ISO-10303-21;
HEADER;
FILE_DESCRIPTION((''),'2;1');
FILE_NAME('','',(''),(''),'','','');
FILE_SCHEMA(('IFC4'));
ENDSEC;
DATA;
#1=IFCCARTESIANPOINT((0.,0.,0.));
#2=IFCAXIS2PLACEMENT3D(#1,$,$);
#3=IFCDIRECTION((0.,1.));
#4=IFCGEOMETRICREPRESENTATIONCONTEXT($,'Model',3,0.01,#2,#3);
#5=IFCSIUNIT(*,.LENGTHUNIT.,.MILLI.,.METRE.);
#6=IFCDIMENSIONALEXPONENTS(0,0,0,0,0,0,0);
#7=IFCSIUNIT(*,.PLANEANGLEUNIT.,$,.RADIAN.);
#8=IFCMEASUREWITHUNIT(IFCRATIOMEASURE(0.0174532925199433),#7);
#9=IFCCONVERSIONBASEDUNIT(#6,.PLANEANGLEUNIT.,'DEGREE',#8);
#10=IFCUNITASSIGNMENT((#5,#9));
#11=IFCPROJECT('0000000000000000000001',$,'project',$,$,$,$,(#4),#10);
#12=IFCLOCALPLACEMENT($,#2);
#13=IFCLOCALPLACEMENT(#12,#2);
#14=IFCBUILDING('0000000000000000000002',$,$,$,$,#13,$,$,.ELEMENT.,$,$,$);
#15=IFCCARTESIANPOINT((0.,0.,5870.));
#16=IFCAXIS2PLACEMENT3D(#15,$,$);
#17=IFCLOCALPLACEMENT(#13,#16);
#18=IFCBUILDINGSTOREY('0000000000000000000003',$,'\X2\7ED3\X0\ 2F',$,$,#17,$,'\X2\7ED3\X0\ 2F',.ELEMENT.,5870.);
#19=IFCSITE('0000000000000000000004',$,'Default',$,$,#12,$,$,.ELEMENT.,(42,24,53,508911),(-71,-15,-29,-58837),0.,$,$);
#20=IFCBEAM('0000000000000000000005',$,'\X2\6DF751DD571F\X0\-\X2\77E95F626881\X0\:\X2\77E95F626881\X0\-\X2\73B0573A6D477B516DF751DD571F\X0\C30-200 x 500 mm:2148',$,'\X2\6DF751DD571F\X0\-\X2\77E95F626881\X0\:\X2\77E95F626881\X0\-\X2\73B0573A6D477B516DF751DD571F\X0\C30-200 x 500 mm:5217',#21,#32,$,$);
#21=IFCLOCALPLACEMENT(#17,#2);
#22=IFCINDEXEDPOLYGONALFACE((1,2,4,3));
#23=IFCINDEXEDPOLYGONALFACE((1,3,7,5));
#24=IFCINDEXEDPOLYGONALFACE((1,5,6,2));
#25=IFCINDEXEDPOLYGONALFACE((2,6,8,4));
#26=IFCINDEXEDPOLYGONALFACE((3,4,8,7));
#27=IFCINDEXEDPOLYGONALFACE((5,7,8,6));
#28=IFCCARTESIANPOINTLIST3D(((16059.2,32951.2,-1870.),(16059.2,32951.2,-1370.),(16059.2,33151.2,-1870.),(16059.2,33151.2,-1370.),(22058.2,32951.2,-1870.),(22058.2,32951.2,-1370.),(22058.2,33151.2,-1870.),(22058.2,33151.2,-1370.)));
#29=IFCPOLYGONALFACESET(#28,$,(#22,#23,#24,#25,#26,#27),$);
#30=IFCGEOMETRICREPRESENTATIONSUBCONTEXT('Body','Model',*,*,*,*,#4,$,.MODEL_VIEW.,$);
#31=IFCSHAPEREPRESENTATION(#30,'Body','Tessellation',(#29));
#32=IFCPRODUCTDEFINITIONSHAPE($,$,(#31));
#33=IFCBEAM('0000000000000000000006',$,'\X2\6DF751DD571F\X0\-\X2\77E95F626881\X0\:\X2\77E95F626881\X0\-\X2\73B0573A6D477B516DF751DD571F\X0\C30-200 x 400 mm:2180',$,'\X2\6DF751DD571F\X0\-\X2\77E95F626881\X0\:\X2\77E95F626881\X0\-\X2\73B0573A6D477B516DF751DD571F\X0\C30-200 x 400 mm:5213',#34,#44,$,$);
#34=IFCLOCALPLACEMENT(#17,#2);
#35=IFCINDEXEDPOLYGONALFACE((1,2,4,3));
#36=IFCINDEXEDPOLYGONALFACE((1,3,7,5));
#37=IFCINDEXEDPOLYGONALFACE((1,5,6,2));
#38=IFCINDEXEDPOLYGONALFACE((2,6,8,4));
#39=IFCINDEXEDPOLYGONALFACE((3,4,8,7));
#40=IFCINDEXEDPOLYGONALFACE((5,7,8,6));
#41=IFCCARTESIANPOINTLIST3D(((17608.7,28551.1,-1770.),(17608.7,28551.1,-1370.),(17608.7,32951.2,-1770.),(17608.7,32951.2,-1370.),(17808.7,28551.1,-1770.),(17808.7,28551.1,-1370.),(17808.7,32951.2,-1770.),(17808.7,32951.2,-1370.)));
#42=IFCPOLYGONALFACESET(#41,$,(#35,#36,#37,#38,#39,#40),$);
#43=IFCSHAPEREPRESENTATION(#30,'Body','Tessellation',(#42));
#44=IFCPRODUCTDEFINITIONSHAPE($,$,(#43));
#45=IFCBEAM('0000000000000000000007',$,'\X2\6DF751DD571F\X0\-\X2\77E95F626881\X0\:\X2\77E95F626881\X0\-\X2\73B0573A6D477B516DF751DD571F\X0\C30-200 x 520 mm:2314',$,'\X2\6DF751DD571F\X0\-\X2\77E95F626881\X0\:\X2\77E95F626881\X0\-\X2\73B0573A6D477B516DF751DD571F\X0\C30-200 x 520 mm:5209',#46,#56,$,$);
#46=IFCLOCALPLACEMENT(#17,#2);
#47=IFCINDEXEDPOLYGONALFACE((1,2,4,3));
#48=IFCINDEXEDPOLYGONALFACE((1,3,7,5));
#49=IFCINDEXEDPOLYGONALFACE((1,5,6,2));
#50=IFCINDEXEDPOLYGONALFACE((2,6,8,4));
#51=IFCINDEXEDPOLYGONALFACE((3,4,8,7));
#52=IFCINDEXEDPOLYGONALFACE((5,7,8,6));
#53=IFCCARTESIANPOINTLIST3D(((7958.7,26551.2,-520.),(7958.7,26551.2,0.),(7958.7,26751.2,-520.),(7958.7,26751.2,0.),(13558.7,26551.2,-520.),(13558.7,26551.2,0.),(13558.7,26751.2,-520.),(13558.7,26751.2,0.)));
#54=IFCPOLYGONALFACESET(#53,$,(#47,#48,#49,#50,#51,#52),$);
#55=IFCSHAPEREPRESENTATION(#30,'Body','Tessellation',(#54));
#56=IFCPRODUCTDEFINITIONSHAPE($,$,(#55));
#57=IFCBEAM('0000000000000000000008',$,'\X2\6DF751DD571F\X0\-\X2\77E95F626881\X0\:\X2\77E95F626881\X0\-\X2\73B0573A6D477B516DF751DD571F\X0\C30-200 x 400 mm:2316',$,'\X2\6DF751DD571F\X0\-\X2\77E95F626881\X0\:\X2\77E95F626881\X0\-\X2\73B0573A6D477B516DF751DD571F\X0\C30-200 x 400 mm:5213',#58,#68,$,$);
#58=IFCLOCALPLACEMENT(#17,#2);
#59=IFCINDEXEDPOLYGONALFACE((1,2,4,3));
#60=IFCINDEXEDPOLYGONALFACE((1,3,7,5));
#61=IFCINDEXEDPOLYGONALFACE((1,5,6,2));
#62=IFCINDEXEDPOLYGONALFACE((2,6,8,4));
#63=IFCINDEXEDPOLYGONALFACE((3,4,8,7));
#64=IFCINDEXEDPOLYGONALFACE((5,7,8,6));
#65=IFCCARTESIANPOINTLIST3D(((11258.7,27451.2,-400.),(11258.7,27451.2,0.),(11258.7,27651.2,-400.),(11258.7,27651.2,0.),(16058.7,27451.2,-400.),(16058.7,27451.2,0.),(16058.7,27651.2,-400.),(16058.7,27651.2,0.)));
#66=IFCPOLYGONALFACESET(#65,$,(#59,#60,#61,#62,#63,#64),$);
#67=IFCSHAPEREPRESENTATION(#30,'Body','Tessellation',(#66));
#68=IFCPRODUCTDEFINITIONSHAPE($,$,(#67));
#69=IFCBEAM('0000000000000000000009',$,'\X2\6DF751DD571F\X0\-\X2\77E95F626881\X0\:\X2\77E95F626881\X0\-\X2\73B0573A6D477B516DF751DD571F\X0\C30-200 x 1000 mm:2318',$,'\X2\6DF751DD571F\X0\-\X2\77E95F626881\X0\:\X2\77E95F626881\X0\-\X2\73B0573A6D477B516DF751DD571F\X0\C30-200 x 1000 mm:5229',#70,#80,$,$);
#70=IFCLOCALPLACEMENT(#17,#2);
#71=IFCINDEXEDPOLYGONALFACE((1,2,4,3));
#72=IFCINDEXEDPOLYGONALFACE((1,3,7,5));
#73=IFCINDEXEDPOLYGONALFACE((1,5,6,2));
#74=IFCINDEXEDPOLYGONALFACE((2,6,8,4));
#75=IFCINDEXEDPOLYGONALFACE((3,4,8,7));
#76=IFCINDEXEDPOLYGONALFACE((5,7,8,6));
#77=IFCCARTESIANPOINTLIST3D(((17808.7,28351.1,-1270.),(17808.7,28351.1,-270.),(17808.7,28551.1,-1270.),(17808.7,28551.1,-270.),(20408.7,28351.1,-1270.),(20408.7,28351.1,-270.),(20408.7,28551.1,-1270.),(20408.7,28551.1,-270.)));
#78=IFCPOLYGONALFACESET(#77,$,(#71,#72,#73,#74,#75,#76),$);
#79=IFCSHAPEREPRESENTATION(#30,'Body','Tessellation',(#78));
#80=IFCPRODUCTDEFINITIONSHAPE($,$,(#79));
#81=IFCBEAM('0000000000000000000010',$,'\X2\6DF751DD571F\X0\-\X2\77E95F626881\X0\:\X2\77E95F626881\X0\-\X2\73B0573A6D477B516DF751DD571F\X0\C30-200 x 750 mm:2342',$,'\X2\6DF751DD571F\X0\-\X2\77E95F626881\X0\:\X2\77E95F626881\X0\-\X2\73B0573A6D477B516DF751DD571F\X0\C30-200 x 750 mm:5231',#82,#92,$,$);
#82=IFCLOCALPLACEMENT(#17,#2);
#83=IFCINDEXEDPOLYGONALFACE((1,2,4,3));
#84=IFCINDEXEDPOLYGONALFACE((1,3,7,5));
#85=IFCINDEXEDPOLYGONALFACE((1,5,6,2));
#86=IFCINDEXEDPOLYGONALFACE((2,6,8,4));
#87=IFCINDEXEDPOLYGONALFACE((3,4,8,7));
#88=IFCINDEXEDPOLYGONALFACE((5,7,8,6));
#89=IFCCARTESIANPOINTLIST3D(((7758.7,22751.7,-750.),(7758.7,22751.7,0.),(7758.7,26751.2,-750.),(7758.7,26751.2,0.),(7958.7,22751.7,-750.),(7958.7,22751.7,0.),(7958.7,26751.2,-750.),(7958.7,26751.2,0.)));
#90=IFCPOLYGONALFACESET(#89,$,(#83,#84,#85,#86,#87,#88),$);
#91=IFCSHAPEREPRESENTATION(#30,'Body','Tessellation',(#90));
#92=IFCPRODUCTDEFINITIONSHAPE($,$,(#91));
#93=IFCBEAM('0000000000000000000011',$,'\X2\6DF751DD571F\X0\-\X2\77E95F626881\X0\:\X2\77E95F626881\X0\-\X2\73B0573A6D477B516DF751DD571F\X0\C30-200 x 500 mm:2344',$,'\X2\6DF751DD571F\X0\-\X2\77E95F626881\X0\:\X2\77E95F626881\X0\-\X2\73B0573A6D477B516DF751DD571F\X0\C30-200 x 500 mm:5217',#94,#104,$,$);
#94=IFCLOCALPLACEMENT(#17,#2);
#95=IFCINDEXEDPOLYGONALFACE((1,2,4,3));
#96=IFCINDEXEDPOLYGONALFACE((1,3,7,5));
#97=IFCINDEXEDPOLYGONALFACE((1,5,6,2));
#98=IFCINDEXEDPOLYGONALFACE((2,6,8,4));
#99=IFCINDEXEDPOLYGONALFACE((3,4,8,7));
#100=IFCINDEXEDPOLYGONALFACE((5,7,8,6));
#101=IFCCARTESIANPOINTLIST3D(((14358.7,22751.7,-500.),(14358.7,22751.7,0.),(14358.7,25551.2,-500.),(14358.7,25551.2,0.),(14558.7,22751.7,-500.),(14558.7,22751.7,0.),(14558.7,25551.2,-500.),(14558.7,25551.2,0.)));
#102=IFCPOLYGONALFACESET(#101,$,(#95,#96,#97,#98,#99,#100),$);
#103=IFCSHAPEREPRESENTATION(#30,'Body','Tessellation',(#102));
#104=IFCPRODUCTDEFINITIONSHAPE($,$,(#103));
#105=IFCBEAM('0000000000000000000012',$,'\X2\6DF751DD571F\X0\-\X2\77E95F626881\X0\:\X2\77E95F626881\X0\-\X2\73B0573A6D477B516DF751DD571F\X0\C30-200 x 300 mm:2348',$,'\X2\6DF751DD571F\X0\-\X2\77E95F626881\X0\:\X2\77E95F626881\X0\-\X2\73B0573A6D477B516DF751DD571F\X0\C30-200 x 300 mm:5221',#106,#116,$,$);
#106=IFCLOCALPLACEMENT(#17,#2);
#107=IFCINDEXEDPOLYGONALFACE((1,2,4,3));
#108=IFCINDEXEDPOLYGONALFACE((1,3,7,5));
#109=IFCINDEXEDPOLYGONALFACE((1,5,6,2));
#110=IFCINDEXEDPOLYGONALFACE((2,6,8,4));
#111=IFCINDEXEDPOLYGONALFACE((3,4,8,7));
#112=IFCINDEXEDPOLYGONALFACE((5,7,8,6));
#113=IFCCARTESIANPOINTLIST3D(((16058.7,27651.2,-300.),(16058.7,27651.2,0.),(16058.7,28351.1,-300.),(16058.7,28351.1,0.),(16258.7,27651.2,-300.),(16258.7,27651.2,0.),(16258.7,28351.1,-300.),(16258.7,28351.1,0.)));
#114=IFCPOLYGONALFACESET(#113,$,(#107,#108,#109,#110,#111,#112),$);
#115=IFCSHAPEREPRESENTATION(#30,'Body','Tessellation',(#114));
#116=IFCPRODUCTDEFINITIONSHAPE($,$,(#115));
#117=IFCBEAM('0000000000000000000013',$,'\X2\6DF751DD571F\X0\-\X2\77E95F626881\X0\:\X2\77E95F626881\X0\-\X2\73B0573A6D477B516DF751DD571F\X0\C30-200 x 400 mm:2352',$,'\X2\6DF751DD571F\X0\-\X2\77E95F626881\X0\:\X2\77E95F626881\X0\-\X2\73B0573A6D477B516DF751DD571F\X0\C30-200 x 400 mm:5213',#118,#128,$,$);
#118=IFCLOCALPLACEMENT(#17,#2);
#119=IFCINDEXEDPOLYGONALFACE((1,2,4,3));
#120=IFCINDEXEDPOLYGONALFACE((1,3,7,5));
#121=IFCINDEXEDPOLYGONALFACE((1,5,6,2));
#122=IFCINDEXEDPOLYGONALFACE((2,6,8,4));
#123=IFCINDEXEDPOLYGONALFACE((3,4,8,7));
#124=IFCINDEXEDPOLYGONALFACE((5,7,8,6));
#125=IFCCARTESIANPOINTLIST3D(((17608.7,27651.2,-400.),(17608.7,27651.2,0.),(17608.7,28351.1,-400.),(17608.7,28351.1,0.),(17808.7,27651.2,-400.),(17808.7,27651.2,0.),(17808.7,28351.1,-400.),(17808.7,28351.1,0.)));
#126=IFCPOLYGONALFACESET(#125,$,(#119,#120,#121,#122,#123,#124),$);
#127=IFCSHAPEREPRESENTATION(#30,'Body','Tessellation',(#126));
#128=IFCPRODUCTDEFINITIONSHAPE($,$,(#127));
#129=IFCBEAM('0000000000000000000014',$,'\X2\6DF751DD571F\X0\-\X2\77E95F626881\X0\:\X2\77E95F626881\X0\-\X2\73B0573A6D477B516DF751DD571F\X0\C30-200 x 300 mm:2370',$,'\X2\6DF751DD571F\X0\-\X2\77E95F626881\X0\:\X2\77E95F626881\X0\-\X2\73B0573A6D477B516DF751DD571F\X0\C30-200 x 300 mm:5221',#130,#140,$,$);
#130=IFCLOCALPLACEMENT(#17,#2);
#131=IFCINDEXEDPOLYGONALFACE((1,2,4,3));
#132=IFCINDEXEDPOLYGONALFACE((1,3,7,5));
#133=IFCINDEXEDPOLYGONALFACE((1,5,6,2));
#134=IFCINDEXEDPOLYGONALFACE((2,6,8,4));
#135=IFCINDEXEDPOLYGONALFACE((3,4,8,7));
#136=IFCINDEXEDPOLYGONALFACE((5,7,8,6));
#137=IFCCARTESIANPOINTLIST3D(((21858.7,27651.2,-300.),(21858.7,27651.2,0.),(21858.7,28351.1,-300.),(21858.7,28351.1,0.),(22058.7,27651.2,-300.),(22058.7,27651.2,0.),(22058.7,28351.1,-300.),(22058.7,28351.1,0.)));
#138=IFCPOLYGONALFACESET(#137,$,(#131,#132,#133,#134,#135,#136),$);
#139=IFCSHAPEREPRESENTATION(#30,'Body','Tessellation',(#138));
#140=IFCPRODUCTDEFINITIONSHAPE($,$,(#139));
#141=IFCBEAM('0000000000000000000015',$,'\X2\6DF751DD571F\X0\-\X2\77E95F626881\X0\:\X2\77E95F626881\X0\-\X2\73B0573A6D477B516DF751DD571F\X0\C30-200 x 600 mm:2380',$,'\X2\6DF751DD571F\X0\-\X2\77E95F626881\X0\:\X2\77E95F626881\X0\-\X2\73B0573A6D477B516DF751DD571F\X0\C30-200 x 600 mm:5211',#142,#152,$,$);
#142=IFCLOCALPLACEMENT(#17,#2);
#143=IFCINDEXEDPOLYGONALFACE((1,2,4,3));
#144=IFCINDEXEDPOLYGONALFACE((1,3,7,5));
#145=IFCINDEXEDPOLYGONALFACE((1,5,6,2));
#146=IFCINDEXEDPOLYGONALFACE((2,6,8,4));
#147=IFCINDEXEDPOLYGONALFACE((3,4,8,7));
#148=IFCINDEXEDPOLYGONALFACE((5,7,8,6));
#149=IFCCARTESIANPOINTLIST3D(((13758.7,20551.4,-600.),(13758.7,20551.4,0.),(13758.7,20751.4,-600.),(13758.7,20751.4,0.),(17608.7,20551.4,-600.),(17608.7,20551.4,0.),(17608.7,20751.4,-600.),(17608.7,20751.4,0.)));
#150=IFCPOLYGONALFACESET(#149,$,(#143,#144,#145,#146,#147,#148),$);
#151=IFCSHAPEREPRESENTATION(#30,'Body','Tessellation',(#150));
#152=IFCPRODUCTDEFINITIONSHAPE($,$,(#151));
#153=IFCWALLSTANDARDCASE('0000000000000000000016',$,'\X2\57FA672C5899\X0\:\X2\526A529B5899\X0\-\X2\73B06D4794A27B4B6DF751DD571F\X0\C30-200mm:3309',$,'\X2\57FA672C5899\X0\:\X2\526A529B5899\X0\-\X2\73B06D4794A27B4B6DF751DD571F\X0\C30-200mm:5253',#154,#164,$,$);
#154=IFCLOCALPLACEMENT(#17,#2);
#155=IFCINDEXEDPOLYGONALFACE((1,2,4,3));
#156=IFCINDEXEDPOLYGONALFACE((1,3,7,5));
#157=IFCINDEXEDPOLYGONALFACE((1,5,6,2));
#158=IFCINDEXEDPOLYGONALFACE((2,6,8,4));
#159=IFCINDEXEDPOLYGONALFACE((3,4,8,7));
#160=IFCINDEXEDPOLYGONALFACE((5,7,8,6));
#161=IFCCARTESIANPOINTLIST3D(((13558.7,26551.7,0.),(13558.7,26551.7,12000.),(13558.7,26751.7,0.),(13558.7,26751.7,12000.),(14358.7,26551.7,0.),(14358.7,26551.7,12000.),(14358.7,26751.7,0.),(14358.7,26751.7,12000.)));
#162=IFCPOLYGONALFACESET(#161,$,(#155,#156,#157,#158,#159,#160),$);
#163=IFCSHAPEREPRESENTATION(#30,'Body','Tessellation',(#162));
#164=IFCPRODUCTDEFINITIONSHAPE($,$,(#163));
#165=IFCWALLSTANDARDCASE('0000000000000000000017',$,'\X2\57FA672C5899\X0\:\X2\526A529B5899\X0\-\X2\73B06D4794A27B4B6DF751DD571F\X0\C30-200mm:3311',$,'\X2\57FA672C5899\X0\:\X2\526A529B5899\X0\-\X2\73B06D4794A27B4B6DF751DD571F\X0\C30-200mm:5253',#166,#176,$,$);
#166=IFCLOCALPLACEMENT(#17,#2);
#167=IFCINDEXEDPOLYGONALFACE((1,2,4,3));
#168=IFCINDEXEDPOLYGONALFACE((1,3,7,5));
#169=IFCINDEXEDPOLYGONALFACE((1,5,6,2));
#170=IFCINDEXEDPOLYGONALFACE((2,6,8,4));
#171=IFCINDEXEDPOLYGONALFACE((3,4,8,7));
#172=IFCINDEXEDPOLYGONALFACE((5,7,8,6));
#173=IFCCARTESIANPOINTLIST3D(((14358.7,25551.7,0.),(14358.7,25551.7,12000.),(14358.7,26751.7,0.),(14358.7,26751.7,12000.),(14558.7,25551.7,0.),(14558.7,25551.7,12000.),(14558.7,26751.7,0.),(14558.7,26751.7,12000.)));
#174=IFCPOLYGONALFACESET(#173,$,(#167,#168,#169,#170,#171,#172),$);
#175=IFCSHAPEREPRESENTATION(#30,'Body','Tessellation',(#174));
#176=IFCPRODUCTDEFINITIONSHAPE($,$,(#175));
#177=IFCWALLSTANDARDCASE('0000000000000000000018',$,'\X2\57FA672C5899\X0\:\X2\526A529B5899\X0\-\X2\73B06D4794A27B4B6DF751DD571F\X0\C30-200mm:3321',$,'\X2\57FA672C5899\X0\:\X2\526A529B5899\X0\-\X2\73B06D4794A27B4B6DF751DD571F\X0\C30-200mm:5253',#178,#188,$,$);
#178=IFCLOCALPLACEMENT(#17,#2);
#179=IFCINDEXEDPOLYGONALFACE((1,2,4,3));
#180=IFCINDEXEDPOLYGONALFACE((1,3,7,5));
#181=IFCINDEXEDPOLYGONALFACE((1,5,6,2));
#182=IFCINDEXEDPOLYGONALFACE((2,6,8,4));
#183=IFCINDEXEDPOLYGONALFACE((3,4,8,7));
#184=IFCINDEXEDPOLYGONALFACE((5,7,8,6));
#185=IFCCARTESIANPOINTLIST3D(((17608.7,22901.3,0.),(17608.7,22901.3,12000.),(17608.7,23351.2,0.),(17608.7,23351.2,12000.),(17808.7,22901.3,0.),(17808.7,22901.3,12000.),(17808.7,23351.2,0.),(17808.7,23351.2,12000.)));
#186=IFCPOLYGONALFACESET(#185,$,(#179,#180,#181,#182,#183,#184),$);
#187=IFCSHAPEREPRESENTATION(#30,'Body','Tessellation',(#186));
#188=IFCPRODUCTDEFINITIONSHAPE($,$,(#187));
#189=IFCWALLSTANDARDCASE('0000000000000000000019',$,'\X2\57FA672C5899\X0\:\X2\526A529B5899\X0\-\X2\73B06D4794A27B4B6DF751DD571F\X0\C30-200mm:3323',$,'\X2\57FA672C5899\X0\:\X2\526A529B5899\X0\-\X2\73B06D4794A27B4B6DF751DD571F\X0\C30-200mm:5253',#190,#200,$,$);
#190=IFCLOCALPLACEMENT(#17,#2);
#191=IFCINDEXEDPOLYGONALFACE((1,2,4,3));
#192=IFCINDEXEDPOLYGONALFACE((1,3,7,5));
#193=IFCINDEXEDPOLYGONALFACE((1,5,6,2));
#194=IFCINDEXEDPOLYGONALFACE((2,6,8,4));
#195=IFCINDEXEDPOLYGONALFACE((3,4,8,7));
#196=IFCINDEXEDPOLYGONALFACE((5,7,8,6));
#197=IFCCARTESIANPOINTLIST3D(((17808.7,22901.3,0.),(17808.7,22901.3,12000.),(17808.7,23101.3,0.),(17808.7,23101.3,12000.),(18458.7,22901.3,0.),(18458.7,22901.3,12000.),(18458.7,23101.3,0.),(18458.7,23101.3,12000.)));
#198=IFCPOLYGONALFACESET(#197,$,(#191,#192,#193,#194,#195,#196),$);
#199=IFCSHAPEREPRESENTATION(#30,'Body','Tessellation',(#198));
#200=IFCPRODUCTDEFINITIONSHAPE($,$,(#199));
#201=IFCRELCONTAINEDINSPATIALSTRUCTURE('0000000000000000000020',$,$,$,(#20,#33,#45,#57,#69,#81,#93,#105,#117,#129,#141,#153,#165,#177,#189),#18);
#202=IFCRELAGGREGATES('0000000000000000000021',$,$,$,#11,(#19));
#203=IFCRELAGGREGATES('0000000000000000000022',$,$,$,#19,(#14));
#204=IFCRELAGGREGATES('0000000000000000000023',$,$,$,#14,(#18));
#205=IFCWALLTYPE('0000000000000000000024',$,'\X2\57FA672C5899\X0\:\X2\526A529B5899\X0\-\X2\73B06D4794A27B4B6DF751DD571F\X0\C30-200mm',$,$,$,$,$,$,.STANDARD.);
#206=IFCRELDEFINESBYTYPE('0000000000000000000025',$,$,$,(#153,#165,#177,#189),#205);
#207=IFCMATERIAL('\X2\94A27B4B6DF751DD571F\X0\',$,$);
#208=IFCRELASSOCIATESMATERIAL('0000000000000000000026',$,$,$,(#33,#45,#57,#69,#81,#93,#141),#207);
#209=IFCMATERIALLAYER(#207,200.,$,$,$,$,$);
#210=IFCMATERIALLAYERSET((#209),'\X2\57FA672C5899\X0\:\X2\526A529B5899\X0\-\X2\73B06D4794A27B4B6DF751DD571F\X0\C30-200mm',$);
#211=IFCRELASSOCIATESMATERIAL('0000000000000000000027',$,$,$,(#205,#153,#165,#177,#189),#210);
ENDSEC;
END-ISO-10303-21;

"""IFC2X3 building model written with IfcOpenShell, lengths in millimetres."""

from ifc_helpers import new_model, entity, si_unit, converted_unit, direction, frame, frame_2d, origin, place, context, subcontext, project, spatial, rectangle, extrude, material, layer, layer_set, layer_usage, type_object, element, save


model = new_model("IFC2X3")

# Units and contexts
model_context = context("Model", 3, precision=0.01, world=origin(), true_north=direction((0.0, 1.0)))
body_context = subcontext(model_context, "Body", "Model", "MODEL_VIEW")
ifc_project = project(units=[si_unit("LENGTHUNIT", "METRE", prefix="MILLI"), converted_unit("PLANEANGLEUNIT", "DEGREE", entity("IfcRatioMeasure", 0.0174532925199433), si_unit("PLANEANGLEUNIT", "RADIAN"), dimensions=[0, 0, 0, 0, 0, 0, 0])], contexts=[model_context])

# Site, building, storey
site_placement = place(None, origin())
site = spatial("IfcSite", under=ifc_project, at=site_placement, Name="Default", CompositionType="ELEMENT", RefLatitude=(42, 24, 53, 508911), RefLongitude=(-71, -15, -29, -58837), RefElevation=0.0)
building_placement = place(site_placement, origin())
building = spatial("IfcBuilding", under=site, at=building_placement, CompositionType="ELEMENT")
storey_placement = place(building_placement, frame((0.0, 0.0, 5870.0)))
storey = spatial("IfcBuildingStorey", under=building, at=storey_placement, Name="结 2F", LongName="结 2F", CompositionType="ELEMENT", Elevation=5870.0)

# Beams
beam_1_placement = place(storey_placement, frame((16058.7, 33151.2, -1370.0)))
element("IfcBeam", 1, at=beam_1_placement, inside=storey, Name="混凝土-矩形梁:矩形梁-现场浇筑混凝土C30-200 x 500 mm:2148", ObjectType="混凝土-矩形梁:矩形梁-现场浇筑混凝土C30-200 x 500 mm:5217", context=body_context, shape_type="SweptSolid", body=[
    extrude(rectangle(XDim=500.0, YDim=200.0, at=frame_2d((0.0, 0.0), x_axis=(1.0, 0.0))), frame((0.5, -100.0, -250.0), z_axis=(1.0, 0.0, 0.0), x_axis=(0.0, 0.0, -1.0)), (0.0, 0.0, 1.0), 5999.0),
])
ifc_material = material(Name="钢筋混凝土")
beam_2_placement = place(storey_placement, frame((17708.7, 28451.1, -1370.0), z_axis=(0.0, 0.0, 1.0), x_axis=(0.0, 1.0, 0.0)))
element("IfcBeam", 2, at=beam_2_placement, inside=storey, material=ifc_material, Name="混凝土-矩形梁:矩形梁-现场浇筑混凝土C30-200 x 400 mm:2180", ObjectType="混凝土-矩形梁:矩形梁-现场浇筑混凝土C30-200 x 400 mm:5213", context=body_context, shape_type="SweptSolid", body=[
    extrude(rectangle(XDim=400.0, YDim=200.0, at=frame_2d((0.0, 0.0), x_axis=(1.0, 0.0))), frame((100.0, 0.0, -200.0), z_axis=(1.0, 0.0, 0.0), x_axis=(0.0, 0.0, -1.0)), (0.0, 0.0, 1.0), 4400.1),
])
beam_3_placement = place(storey_placement, frame((7858.7, 26651.2, 0.0)))
element("IfcBeam", 3, at=beam_3_placement, inside=storey, material=ifc_material, Name="混凝土-矩形梁:矩形梁-现场浇筑混凝土C30-200 x 520 mm:2314", ObjectType="混凝土-矩形梁:矩形梁-现场浇筑混凝土C30-200 x 520 mm:5209", context=body_context, shape_type="SweptSolid", body=[
    extrude(rectangle(XDim=520.0, YDim=200.0, at=frame_2d((0.0, 0.0), x_axis=(1.0, 0.0))), frame((100.0, 0.0, -260.0), z_axis=(1.0, 0.0, 0.0), x_axis=(0.0, 0.0, -1.0)), (0.0, 0.0, 1.0), 5600.0),
])
beam_4_placement = place(storey_placement, frame((11158.7, 27551.2, 0.0)))
element("IfcBeam", 4, at=beam_4_placement, inside=storey, material=ifc_material, Name="混凝土-矩形梁:矩形梁-现场浇筑混凝土C30-200 x 400 mm:2316", ObjectType="混凝土-矩形梁:矩形梁-现场浇筑混凝土C30-200 x 400 mm:5213", context=body_context, shape_type="SweptSolid", body=[
    extrude(rectangle(XDim=400.0, YDim=200.0, at=frame_2d((0.0, 0.0), x_axis=(1.0, 0.0))), frame((100.0, 0.0, -200.0), z_axis=(1.0, 0.0, 0.0), x_axis=(0.0, 0.0, -1.0)), (0.0, 0.0, 1.0), 4800.0),
])
beam_5_placement = place(storey_placement, frame((16168.7, 28451.1, -270.0)))
element("IfcBeam", 5, at=beam_5_placement, inside=storey, material=ifc_material, Name="混凝土-矩形梁:矩形梁-现场浇筑混凝土C30-200 x 1000 mm:2318", ObjectType="混凝土-矩形梁:矩形梁-现场浇筑混凝土C30-200 x 1000 mm:5229", context=body_context, shape_type="SweptSolid", body=[
    extrude(rectangle(XDim=1000.0, YDim=200.0, at=frame_2d((0.0, 0.0), x_axis=(1.0, 0.0))), frame((1640.0, 0.0, -500.0), z_axis=(1.0, 0.0, 0.0), x_axis=(0.0, 0.0, -1.0)), (0.0, 0.0, 1.0), 2600.0),
])
beam_6_placement = place(storey_placement, frame((7858.7, 22651.7, 0.0), z_axis=(0.0, 0.0, 1.0), x_axis=(0.0, 1.0, 0.0)))
element("IfcBeam", 6, at=beam_6_placement, inside=storey, material=ifc_material, Name="混凝土-矩形梁:矩形梁-现场浇筑混凝土C30-200 x 750 mm:2342", ObjectType="混凝土-矩形梁:矩形梁-现场浇筑混凝土C30-200 x 750 mm:5231", context=body_context, shape_type="SweptSolid", body=[
    extrude(rectangle(XDim=750.0, YDim=200.0, at=frame_2d((0.0, 0.0), x_axis=(1.0, 0.0))), frame((100.0, 0.0, -375.0), z_axis=(1.0, 0.0, 0.0), x_axis=(0.0, 0.0, -1.0)), (0.0, 0.0, 1.0), 3999.5),
])
beam_7_placement = place(storey_placement, frame((14458.7, 22651.7, 0.0), z_axis=(0.0, 0.0, 1.0), x_axis=(0.0, 1.0, 0.0)))
element("IfcBeam", 7, at=beam_7_placement, inside=storey, material=ifc_material, Name="混凝土-矩形梁:矩形梁-现场浇筑混凝土C30-200 x 500 mm:2344", ObjectType="混凝土-矩形梁:矩形梁-现场浇筑混凝土C30-200 x 500 mm:5217", context=body_context, shape_type="SweptSolid", body=[
    extrude(rectangle(XDim=500.0, YDim=200.0, at=frame_2d((0.0, 0.0), x_axis=(1.0, 0.0))), frame((100.0, 0.0, -250.0), z_axis=(1.0, 0.0, 0.0), x_axis=(0.0, 0.0, -1.0)), (0.0, 0.0, 1.0), 2799.5),
])
beam_8_placement = place(storey_placement, frame((16158.7, 27551.2, 0.0), z_axis=(0.0, 0.0, 1.0), x_axis=(0.0, 1.0, 0.0)))
element("IfcBeam", 8, at=beam_8_placement, inside=storey, Name="混凝土-矩形梁:矩形梁-现场浇筑混凝土C30-200 x 300 mm:2348", ObjectType="混凝土-矩形梁:矩形梁-现场浇筑混凝土C30-200 x 300 mm:5221", context=body_context, shape_type="SweptSolid", body=[
    extrude(rectangle(XDim=300.0, YDim=200.0, at=frame_2d((0.0, 0.0), x_axis=(1.0, 0.0))), frame((100.0, 0.0, -150.0), z_axis=(1.0, 0.0, 0.0), x_axis=(0.0, 0.0, -1.0)), (0.0, 0.0, 1.0), 699.9),
])
beam_9_placement = place(storey_placement, frame((17708.7, 27551.2, 0.0), z_axis=(0.0, 0.0, 1.0), x_axis=(0.0, 1.0, 0.0)))
element("IfcBeam", 9, at=beam_9_placement, inside=storey, Name="混凝土-矩形梁:矩形梁-现场浇筑混凝土C30-200 x 400 mm:2352", ObjectType="混凝土-矩形梁:矩形梁-现场浇筑混凝土C30-200 x 400 mm:5213", context=body_context, shape_type="SweptSolid", body=[
    extrude(rectangle(XDim=400.0, YDim=200.0, at=frame_2d((0.0, 0.0), x_axis=(1.0, 0.0))), frame((100.0, 0.0, -200.0), z_axis=(1.0, 0.0, 0.0), x_axis=(0.0, 0.0, -1.0)), (0.0, 0.0, 1.0), 699.9),
])
beam_10_placement = place(storey_placement, frame((21958.7, 27551.2, 0.0), z_axis=(0.0, 0.0, 1.0), x_axis=(0.0, 1.0, 0.0)))
element("IfcBeam", 10, at=beam_10_placement, inside=storey, Name="混凝土-矩形梁:矩形梁-现场浇筑混凝土C30-200 x 300 mm:2370", ObjectType="混凝土-矩形梁:矩形梁-现场浇筑混凝土C30-200 x 300 mm:5221", context=body_context, shape_type="SweptSolid", body=[
    extrude(rectangle(XDim=300.0, YDim=200.0, at=frame_2d((0.0, 0.0), x_axis=(1.0, 0.0))), frame((100.0, 0.0, -150.0), z_axis=(1.0, 0.0, 0.0), x_axis=(0.0, 0.0, -1.0)), (0.0, 0.0, 1.0), 699.9),
])
beam_11_placement = place(storey_placement, frame((13658.7, 20651.4, 0.0)))
element("IfcBeam", 11, at=beam_11_placement, inside=storey, material=ifc_material, Name="混凝土-矩形梁:矩形梁-现场浇筑混凝土C30-200 x 600 mm:2380", ObjectType="混凝土-矩形梁:矩形梁-现场浇筑混凝土C30-200 x 600 mm:5211", context=body_context, shape_type="SweptSolid", body=[
    extrude(rectangle(XDim=600.0, YDim=200.0, at=frame_2d((0.0, 0.0), x_axis=(1.0, 0.0))), frame((100.0, 0.0, -300.0), z_axis=(1.0, 0.0, 0.0), x_axis=(0.0, 0.0, -1.0)), (0.0, 0.0, 1.0), 3850.0),
])

# Walls
ifc_layer = layer(ifc_material, 200.0)
ifc_layer_set = layer_set([ifc_layer], Name="基本墙:剪力墙-现浇钢筋混凝土C30-200mm")
ifc_layer_usage_1 = layer_usage(ifc_layer_set, "AXIS2", "NEGATIVE", 100.0)
wall_type = type_object("IfcWallType", Name="基本墙:剪力墙-现浇钢筋混凝土C30-200mm", PredefinedType="STANDARD", material=ifc_layer_set)
wall_1_placement = place(storey_placement, frame((13558.7, 26651.7, 0.0)))
element("IfcWallStandardCase", 12, at=wall_1_placement, inside=storey, type_object=wall_type, material=ifc_layer_usage_1, Name="基本墙:剪力墙-现浇钢筋混凝土C30-200mm:3309", ObjectType="基本墙:剪力墙-现浇钢筋混凝土C30-200mm:5253", context=body_context, shape_type="SweptSolid", body=[
    extrude(rectangle(XDim=800.0, YDim=200.0, at=frame_2d((400.0, 0.0), x_axis=(-1.0, 0.0))), origin(), (0.0, 0.0, 1.0), 12000.0),
])
ifc_layer_usage_2 = layer_usage(ifc_layer_set, "AXIS2", "NEGATIVE", 100.0)
wall_2_placement = place(storey_placement, frame((14458.7, 26751.7, 0.0), z_axis=(0.0, 0.0, 1.0), x_axis=(0.0, -1.0, 0.0)))
element("IfcWallStandardCase", 13, at=wall_2_placement, inside=storey, type_object=wall_type, material=ifc_layer_usage_2, Name="基本墙:剪力墙-现浇钢筋混凝土C30-200mm:3311", ObjectType="基本墙:剪力墙-现浇钢筋混凝土C30-200mm:5253", context=body_context, shape_type="SweptSolid", body=[
    extrude(rectangle(XDim=1200.0, YDim=200.0, at=frame_2d((600.0, 0.0), x_axis=(-1.0, 0.0))), origin(), (0.0, 0.0, 1.0), 12000.0),
])
ifc_layer_usage_3 = layer_usage(ifc_layer_set, "AXIS2", "NEGATIVE", 100.0)
wall_3_placement = place(storey_placement, frame((17708.7, 23351.2, 0.0), z_axis=(0.0, 0.0, 1.0), x_axis=(0.0, -1.0, 0.0)))
element("IfcWallStandardCase", 14, at=wall_3_placement, inside=storey, type_object=wall_type, material=ifc_layer_usage_3, Name="基本墙:剪力墙-现浇钢筋混凝土C30-200mm:3321", ObjectType="基本墙:剪力墙-现浇钢筋混凝土C30-200mm:5253", context=body_context, shape_type="SweptSolid", body=[
    extrude(rectangle(XDim=449.9, YDim=200.0, at=frame_2d((225.0, 0.0), x_axis=(-1.0, 0.0))), origin(), (0.0, 0.0, 1.0), 12000.0),
])
ifc_layer_usage_4 = layer_usage(ifc_layer_set, "AXIS2", "NEGATIVE", 100.0)
wall_4_placement = place(storey_placement, frame((17808.7, 23001.3, 0.0)))
element("IfcWallStandardCase", 15, at=wall_4_placement, inside=storey, type_object=wall_type, material=ifc_layer_usage_4, Name="基本墙:剪力墙-现浇钢筋混凝土C30-200mm:3323", ObjectType="基本墙:剪力墙-现浇钢筋混凝土C30-200mm:5253", context=body_context, shape_type="SweptSolid", body=[
    extrude(rectangle(XDim=650.0, YDim=200.0, at=frame_2d((325.0, 0.0), x_axis=(-1.0, 0.0))), origin(), (0.0, 0.0, 1.0), 12000.0),
])

save(model, "model.ifc")
